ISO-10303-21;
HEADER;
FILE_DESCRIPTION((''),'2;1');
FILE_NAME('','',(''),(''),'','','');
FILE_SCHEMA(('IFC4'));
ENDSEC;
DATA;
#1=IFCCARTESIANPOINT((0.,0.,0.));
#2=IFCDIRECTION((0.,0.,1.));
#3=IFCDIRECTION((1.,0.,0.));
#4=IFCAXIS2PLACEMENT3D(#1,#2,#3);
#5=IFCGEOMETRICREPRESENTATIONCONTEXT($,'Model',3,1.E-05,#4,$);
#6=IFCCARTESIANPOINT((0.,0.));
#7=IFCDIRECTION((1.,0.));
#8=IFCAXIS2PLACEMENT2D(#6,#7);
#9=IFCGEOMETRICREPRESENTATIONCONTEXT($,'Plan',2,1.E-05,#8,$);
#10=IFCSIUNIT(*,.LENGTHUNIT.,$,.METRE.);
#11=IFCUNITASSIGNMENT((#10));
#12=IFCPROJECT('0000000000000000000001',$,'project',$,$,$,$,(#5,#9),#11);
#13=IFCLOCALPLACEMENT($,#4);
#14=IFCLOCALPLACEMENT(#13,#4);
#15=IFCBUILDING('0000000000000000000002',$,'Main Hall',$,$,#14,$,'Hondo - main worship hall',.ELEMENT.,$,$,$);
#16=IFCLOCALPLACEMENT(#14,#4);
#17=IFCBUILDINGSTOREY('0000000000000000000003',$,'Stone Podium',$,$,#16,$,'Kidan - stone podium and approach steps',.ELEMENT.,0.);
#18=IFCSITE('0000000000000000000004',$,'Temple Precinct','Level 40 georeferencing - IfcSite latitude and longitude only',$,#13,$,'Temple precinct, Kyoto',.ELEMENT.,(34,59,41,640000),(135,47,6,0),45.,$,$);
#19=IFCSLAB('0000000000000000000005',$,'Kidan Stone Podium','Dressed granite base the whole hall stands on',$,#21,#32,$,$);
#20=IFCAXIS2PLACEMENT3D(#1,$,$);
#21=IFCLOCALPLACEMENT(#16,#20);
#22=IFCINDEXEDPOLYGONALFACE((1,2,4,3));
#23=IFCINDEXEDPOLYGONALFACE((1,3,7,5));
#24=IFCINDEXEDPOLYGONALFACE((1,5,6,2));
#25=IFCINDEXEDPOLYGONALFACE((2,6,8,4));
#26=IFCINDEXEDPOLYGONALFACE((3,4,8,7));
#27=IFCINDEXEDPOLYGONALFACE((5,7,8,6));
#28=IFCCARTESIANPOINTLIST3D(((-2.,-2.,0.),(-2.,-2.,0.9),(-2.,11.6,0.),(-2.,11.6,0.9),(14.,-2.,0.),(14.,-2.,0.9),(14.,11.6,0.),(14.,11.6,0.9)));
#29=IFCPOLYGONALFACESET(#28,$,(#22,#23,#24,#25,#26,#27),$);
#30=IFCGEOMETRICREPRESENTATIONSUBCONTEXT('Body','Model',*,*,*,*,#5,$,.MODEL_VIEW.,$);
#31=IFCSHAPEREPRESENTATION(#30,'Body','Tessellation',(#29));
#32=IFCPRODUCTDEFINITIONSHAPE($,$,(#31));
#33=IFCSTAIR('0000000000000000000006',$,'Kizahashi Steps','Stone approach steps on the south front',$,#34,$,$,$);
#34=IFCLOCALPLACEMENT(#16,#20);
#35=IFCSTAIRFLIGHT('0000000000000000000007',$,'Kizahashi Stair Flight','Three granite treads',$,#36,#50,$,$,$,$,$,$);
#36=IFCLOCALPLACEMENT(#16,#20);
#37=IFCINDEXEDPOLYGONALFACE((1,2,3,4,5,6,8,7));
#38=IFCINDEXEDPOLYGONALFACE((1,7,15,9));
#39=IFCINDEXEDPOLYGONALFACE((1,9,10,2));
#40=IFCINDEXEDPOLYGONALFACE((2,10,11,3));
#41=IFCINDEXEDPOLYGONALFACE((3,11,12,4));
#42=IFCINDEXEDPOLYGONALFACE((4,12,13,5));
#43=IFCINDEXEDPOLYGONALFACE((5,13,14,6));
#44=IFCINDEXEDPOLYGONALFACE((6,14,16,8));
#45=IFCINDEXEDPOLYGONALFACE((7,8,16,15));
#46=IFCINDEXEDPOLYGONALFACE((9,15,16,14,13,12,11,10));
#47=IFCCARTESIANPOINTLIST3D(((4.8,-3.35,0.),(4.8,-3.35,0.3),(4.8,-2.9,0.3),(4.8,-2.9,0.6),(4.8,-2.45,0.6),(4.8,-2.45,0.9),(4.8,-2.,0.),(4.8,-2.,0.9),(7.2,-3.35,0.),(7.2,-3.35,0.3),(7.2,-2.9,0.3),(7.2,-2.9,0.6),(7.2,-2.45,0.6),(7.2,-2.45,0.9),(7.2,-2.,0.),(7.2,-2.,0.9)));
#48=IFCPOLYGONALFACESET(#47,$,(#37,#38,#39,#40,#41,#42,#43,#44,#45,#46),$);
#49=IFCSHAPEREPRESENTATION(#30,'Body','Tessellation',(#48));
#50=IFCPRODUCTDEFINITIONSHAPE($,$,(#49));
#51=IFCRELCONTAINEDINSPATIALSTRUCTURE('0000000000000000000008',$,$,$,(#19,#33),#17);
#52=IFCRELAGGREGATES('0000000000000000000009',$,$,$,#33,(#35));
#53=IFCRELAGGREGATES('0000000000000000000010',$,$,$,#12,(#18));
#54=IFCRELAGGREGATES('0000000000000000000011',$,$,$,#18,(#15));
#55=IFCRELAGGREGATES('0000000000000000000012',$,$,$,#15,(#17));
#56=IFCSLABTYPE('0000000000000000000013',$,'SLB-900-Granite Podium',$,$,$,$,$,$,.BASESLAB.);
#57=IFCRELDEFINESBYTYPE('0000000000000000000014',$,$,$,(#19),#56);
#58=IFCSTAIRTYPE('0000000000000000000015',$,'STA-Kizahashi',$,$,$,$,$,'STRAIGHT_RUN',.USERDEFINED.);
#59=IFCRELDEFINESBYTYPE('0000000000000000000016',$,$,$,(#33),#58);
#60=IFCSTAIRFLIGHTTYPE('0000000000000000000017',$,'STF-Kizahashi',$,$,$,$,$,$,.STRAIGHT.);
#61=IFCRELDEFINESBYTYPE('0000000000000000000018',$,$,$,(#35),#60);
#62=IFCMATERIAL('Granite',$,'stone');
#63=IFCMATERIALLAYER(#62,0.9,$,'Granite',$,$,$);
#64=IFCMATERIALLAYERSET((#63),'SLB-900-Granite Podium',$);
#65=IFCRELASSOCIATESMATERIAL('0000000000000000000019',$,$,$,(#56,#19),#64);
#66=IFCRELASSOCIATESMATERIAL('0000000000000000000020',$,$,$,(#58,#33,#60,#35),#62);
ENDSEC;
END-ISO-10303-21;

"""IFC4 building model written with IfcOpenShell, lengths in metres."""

from ifc_helpers import new_model, si_unit, frame, origin_with_axes, origin_2d_with_axis, place, context, subcontext, project, spatial, line, indexed_curve, outline, extrude, material, layer, layer_set, layer_usage, type_object, element, aggregate, save


model = new_model("IFC4")

# Units and contexts
model_context = context("Model", 3, precision=1e-05, world=origin_with_axes())
plan_context = context("Plan", 2, precision=1e-05, world=origin_2d_with_axis())
body_context = subcontext(model_context, "Body", "Model", "MODEL_VIEW")
ifc_project = project(units=[si_unit("LENGTHUNIT", "METRE")], contexts=[model_context, plan_context])

# Site, building, storey
site_placement = place(None, origin_with_axes())
site = spatial("IfcSite", under=ifc_project, at=site_placement, Name="Temple Precinct", Description="Level 40 georeferencing - IfcSite latitude and longitude only", LongName="Temple precinct, Kyoto", CompositionType="ELEMENT", RefLatitude=(34, 59, 41, 640000), RefLongitude=(135, 47, 6, 0), RefElevation=45.0)
building_placement = place(site_placement, origin_with_axes())
building = spatial("IfcBuilding", under=site, at=building_placement, Name="Main Hall", LongName="Hondo - main worship hall", CompositionType="ELEMENT")
storey_placement = place(building_placement, origin_with_axes())
storey = spatial("IfcBuildingStorey", under=building, at=storey_placement, Name="Stone Podium", LongName="Kidan - stone podium and approach steps", CompositionType="ELEMENT", Elevation=0.0)

# Slab
ifc_material = material(Name="Granite", Category="stone")
ifc_layer = layer(ifc_material, 0.9, Name="Granite")
ifc_layer_set = layer_set([ifc_layer], Name="SLB-900-Granite Podium")
ifc_layer_usage = layer_usage(ifc_layer_set, "AXIS3", "POSITIVE", 0.0)
slab_type = type_object("IfcSlabType", Name="SLB-900-Granite Podium", PredefinedType="BASESLAB", material=ifc_layer_set)
slab_placement = place(storey_placement, frame((-2.0, -2.0, 0.0), z_axis=(0.0, 0.0, 1.0), x_axis=(1.0, 0.0, 0.0)))
element("IfcSlab", 1, at=slab_placement, inside=storey, type_object=slab_type, material=ifc_layer_usage, Name="Kidan Stone Podium", Description="Dressed granite base the whole hall stands on", context=body_context, shape_type="SweptSolid", body=[
    extrude(outline(indexed_curve([(0.0, 0.0), (16.0, 0.0), (16.0, 13.6), (0.0, 13.6)], segments=[line(1, 2, 3, 4, 1)])), origin_with_axes(), (0.0, 0.0, 1.0), 0.9),
])

# Stair, stair flight
stair_type = type_object("IfcStairType", Name="STA-Kizahashi", ElementType="STRAIGHT_RUN", PredefinedType="USERDEFINED", material=ifc_material)
stair_placement = place(storey_placement, frame((4.8, -3.35, 0.0), z_axis=(0.0, 0.0, 1.0), x_axis=(1.0, 0.0, 0.0)))
stair = element("IfcStair", 2, at=stair_placement, inside=storey, type_object=stair_type, material=ifc_material, Name="Kizahashi Steps", Description="Stone approach steps on the south front")
stair_flight_type = type_object("IfcStairFlightType", Name="STF-Kizahashi", PredefinedType="STRAIGHT", material=ifc_material)
stair_flight_placement = place(stair_placement, frame((0.0, 0.0, 0.0), z_axis=(1.0, 0.0, 0.0), x_axis=(0.0, 1.0, 0.0)))
stair_flight = element("IfcStairFlight", 3, at=stair_flight_placement, type_object=stair_flight_type, material=ifc_material, Name="Kizahashi Stair Flight", Description="Three granite treads", context=body_context, shape_type="SweptSolid", body=[
    extrude(outline(indexed_curve([(0.0, 0.0), (1.35, 0.0), (1.35, 0.9), (0.9, 0.9), (0.9, 0.6), (0.45, 0.6), (0.45, 0.3), (0.0, 0.3)], segments=[line(1, 2, 3, 4, 5, 6, 7, 8, 1)])), origin_with_axes(), (0.0, 0.0, 1.0), 2.4),
])
aggregate(stair, [stair_flight])

save(model, "model.ifc")
